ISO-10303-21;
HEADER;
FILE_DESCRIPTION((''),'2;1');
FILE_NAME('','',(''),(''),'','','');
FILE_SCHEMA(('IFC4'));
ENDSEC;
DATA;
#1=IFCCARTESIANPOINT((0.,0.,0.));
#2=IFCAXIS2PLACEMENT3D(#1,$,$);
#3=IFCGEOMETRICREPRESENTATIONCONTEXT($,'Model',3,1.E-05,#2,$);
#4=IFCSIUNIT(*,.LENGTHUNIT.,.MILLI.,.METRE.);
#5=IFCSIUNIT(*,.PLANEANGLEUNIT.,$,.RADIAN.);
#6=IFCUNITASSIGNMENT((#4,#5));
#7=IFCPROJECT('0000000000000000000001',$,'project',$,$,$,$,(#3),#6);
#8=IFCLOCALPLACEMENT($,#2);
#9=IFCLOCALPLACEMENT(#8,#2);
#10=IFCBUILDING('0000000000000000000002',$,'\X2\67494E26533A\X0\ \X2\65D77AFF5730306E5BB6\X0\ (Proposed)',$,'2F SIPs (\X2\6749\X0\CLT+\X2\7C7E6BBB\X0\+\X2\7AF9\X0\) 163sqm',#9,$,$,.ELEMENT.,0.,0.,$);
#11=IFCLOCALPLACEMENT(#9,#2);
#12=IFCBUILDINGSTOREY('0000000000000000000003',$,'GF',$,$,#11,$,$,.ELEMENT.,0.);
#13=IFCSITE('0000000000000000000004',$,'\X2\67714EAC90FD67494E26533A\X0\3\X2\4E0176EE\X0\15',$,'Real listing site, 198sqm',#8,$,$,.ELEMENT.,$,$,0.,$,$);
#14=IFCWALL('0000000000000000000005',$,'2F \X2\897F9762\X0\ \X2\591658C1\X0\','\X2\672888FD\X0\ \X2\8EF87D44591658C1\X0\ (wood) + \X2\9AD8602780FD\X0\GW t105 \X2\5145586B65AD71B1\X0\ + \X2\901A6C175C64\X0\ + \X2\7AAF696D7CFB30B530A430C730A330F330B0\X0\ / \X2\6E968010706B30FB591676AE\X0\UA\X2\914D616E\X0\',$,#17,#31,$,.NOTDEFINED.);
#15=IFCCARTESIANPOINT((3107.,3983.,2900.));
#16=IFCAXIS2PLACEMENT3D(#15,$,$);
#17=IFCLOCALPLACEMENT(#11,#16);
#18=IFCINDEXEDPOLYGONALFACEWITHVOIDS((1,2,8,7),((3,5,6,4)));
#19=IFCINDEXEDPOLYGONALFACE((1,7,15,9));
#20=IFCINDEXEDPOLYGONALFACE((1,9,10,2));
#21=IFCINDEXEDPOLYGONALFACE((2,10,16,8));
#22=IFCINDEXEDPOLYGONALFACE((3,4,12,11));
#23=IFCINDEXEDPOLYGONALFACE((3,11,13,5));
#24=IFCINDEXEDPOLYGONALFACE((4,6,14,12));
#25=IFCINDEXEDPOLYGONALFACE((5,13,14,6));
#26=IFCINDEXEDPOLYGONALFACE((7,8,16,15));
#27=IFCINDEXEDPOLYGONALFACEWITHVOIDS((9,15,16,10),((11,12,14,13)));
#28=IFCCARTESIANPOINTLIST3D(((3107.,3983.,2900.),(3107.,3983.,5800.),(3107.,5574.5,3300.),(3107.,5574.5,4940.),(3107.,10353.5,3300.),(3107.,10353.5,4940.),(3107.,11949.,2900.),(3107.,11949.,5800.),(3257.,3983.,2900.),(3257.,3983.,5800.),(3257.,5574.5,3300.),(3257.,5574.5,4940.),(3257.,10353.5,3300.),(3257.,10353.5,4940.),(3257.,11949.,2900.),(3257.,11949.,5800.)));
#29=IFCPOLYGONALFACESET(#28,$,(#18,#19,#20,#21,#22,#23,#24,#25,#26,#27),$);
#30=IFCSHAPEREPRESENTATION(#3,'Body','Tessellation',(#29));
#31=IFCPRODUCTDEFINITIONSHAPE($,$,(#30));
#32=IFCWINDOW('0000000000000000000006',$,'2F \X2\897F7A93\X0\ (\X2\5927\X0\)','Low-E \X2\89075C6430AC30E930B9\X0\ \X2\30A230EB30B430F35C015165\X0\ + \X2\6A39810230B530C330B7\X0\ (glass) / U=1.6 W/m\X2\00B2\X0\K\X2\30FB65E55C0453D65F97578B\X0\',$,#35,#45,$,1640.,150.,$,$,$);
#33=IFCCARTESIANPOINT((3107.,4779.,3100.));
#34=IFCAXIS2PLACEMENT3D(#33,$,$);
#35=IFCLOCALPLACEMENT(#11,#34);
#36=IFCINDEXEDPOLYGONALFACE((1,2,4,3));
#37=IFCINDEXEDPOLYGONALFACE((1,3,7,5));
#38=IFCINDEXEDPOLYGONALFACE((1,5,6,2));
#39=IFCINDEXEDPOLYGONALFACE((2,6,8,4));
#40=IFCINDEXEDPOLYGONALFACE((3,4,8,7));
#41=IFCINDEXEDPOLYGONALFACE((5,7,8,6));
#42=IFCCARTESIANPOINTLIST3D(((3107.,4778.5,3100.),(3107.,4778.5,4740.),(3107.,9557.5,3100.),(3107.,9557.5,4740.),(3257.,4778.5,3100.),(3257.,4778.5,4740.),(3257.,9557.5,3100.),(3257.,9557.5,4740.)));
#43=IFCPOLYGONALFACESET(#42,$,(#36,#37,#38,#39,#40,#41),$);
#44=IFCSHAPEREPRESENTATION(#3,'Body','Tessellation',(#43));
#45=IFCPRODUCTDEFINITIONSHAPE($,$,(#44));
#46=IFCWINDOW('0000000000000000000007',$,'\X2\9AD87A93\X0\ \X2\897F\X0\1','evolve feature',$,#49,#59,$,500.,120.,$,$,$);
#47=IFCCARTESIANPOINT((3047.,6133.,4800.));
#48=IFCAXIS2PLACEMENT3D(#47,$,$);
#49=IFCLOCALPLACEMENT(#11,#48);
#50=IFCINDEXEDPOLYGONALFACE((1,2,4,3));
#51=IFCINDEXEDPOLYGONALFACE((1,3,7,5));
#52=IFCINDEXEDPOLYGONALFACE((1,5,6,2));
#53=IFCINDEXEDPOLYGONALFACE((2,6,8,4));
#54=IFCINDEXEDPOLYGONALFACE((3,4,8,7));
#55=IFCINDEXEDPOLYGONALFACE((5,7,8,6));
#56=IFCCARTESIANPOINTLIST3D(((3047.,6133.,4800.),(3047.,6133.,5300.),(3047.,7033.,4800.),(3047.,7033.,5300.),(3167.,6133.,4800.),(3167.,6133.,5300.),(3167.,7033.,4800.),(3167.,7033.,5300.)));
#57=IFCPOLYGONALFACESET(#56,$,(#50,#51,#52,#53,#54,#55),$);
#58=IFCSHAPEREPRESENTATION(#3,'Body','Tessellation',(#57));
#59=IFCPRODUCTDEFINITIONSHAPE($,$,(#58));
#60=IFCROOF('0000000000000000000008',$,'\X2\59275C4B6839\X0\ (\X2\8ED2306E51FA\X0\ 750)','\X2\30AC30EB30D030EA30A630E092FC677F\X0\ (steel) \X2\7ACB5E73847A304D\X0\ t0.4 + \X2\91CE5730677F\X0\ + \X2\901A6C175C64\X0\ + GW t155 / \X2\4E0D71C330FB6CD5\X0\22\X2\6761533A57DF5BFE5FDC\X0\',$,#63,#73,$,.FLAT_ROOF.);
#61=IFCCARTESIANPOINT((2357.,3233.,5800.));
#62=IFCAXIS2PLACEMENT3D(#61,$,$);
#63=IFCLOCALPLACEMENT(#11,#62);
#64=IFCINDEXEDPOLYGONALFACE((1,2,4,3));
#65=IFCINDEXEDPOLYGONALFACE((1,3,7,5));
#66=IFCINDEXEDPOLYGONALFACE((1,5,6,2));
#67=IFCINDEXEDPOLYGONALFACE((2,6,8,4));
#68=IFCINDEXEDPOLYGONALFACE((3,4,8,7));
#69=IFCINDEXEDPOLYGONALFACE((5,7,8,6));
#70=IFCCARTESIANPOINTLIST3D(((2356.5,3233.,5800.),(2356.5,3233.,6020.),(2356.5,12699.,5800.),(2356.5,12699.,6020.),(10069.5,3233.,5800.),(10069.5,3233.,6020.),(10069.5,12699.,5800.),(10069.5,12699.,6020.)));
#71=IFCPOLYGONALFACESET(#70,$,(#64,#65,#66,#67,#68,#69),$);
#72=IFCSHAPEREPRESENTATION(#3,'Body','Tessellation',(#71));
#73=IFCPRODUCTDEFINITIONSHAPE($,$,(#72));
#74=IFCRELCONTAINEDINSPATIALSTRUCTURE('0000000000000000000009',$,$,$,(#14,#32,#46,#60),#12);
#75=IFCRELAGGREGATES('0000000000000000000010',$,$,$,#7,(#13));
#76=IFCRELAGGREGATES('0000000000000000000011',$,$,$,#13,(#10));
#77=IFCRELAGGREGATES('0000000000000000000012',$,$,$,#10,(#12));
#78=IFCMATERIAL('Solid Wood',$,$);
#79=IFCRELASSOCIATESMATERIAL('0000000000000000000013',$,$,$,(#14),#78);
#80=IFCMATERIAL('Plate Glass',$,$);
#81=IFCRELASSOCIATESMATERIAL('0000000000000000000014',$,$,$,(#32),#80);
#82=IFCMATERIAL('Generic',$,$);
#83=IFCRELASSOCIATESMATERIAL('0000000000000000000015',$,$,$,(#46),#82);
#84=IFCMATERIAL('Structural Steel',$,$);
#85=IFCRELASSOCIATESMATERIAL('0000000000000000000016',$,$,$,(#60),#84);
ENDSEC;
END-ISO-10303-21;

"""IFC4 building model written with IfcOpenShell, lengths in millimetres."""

from ifc_helpers import new_model, si_unit, frame, frame_2d, origin, place, context, project, spatial, rectangle, extrude, material, element, fill, save


model = new_model("IFC4")

# Units and contexts
model_context = context("Model", 3, precision=1e-05, world=origin())
ifc_project = project(units=[si_unit("LENGTHUNIT", "METRE", prefix="MILLI"), si_unit("PLANEANGLEUNIT", "RADIAN")], contexts=[model_context])

# Site, building, storey
site_placement = place(None, origin())
site = spatial("IfcSite", under=ifc_project, at=site_placement, Name="東京都杉並区3丁目15", ObjectType="Real listing site, 198sqm", CompositionType="ELEMENT", RefElevation=0.0)
building_placement = place(site_placement, origin())
building = spatial("IfcBuilding", under=site, at=building_placement, Name="杉並区 旗竿地の家 (Proposed)", ObjectType="2F SIPs (杉CLT+籾殻+竹) 163sqm", CompositionType="ELEMENT", ElevationOfRefHeight=0.0, ElevationOfTerrain=0.0)
storey_placement = place(building_placement, origin())
storey = spatial("IfcBuildingStorey", under=building, at=storey_placement, Name="GF", CompositionType="ELEMENT", Elevation=0.0)

# Shared definitions
ifc_material_1 = material(Name="Solid Wood")
ifc_material_2 = material(Name="Generic")

# Shared definitions
ifc_material_3 = material(Name="Plate Glass")

# Wall, openings, windows
wall_1_placement = place(storey_placement, frame((3107.0, 3983.0, 2900.0)))
wall_1 = element("IfcWall", 1, at=wall_1_placement, inside=storey, material=ifc_material_1, Name="2F 西面 外壁", Description="木製 軸組外壁 (wood) + 高性能GW t105 充填断熱 + 通気層 + 窯業系サイディング / 準耐火・外皮UA配慮", PredefinedType="NOTDEFINED", context=model_context, shape_type="SweptSolid", body=[
    extrude(rectangle(XDim=150.0, YDim=7966.0, at=frame_2d((75.0, 3983.0))), frame((3107.0, 3983.0, 2900.0)), (0.0, 0.0, 1.0), 2900.0),
])
opening_1_placement = place(storey_placement, frame((3107.0, 4779.0, 3100.0)))
opening_1 = element("IfcOpeningElement", 2, at=opening_1_placement, cuts=wall_1, PredefinedType="NOTDEFINED", context=model_context, shape_type="SweptSolid", body=[
    extrude(rectangle(XDim=150.0, YDim=4779.0, at=frame_2d((75.0, 2389.0))), frame((3107.0, 4779.0, 3100.0)), (0.0, 0.0, 1.0), 1640.0),
])
opening_2_placement = place(storey_placement, frame((3047.0, 6133.0, 4800.0)))
opening_2 = element("IfcOpeningElement", 3, at=opening_2_placement, cuts=wall_1, PredefinedType="NOTDEFINED", context=model_context, shape_type="SweptSolid", body=[
    extrude(rectangle(XDim=120.0, YDim=900.0, at=frame_2d((60.0, 450.0))), frame((3047.0, 6133.0, 4800.0)), (0.0, 0.0, 1.0), 500.0),
])
window_1_placement = place(storey_placement, frame((3107.0, 4779.0, 3100.0)))
window_1 = element("IfcWindow", 4, at=window_1_placement, inside=storey, material=ifc_material_3, Name="2F 西窓 (大)", Description="Low-E 複層ガラス アルゴン封入 + 樹脂サッシ (glass) / U=1.6 W/m²K・日射取得型", OverallHeight=1640.0, OverallWidth=150.0, context=model_context, shape_type="SweptSolid", body=[
    extrude(rectangle(XDim=150.0, YDim=4779.0, at=frame_2d((75.0, 2389.0))), frame((3107.0, 4779.0, 3100.0)), (0.0, 0.0, 1.0), 1640.0),
])
fill(opening_1, window_1)
window_2_placement = place(storey_placement, frame((3047.0, 6133.0, 4800.0)))
window_2 = element("IfcWindow", 5, at=window_2_placement, inside=storey, material=ifc_material_2, Name="高窓 西1", Description="evolve feature", OverallHeight=500.0, OverallWidth=120.0, context=model_context, shape_type="SweptSolid", body=[
    extrude(rectangle(XDim=120.0, YDim=900.0, at=frame_2d((60.0, 450.0))), frame((3047.0, 6133.0, 4800.0)), (0.0, 0.0, 1.0), 500.0),
])
fill(opening_2, window_2)

# Roof
ifc_material_4 = material(Name="Structural Steel")
roof_1_placement = place(storey_placement, frame((2357.0, 3233.0, 5800.0)))
element("IfcRoof", 6, at=roof_1_placement, inside=storey, material=ifc_material_4, Name="大屋根 (軒の出 750)", Description="ガルバリウム鋼板 (steel) 立平葺き t0.4 + 野地板 + 通気層 + GW t155 / 不燃・法22条区域対応", PredefinedType="FLAT_ROOF", context=model_context, shape_type="SweptSolid", body=[
    extrude(rectangle(XDim=7713.0, YDim=9466.0, at=frame_2d((3856.0, 4733.0))), frame((2357.0, 3233.0, 5800.0)), (0.0, 0.0, 1.0), 220.0),
])

save(model, "model.ifc")
